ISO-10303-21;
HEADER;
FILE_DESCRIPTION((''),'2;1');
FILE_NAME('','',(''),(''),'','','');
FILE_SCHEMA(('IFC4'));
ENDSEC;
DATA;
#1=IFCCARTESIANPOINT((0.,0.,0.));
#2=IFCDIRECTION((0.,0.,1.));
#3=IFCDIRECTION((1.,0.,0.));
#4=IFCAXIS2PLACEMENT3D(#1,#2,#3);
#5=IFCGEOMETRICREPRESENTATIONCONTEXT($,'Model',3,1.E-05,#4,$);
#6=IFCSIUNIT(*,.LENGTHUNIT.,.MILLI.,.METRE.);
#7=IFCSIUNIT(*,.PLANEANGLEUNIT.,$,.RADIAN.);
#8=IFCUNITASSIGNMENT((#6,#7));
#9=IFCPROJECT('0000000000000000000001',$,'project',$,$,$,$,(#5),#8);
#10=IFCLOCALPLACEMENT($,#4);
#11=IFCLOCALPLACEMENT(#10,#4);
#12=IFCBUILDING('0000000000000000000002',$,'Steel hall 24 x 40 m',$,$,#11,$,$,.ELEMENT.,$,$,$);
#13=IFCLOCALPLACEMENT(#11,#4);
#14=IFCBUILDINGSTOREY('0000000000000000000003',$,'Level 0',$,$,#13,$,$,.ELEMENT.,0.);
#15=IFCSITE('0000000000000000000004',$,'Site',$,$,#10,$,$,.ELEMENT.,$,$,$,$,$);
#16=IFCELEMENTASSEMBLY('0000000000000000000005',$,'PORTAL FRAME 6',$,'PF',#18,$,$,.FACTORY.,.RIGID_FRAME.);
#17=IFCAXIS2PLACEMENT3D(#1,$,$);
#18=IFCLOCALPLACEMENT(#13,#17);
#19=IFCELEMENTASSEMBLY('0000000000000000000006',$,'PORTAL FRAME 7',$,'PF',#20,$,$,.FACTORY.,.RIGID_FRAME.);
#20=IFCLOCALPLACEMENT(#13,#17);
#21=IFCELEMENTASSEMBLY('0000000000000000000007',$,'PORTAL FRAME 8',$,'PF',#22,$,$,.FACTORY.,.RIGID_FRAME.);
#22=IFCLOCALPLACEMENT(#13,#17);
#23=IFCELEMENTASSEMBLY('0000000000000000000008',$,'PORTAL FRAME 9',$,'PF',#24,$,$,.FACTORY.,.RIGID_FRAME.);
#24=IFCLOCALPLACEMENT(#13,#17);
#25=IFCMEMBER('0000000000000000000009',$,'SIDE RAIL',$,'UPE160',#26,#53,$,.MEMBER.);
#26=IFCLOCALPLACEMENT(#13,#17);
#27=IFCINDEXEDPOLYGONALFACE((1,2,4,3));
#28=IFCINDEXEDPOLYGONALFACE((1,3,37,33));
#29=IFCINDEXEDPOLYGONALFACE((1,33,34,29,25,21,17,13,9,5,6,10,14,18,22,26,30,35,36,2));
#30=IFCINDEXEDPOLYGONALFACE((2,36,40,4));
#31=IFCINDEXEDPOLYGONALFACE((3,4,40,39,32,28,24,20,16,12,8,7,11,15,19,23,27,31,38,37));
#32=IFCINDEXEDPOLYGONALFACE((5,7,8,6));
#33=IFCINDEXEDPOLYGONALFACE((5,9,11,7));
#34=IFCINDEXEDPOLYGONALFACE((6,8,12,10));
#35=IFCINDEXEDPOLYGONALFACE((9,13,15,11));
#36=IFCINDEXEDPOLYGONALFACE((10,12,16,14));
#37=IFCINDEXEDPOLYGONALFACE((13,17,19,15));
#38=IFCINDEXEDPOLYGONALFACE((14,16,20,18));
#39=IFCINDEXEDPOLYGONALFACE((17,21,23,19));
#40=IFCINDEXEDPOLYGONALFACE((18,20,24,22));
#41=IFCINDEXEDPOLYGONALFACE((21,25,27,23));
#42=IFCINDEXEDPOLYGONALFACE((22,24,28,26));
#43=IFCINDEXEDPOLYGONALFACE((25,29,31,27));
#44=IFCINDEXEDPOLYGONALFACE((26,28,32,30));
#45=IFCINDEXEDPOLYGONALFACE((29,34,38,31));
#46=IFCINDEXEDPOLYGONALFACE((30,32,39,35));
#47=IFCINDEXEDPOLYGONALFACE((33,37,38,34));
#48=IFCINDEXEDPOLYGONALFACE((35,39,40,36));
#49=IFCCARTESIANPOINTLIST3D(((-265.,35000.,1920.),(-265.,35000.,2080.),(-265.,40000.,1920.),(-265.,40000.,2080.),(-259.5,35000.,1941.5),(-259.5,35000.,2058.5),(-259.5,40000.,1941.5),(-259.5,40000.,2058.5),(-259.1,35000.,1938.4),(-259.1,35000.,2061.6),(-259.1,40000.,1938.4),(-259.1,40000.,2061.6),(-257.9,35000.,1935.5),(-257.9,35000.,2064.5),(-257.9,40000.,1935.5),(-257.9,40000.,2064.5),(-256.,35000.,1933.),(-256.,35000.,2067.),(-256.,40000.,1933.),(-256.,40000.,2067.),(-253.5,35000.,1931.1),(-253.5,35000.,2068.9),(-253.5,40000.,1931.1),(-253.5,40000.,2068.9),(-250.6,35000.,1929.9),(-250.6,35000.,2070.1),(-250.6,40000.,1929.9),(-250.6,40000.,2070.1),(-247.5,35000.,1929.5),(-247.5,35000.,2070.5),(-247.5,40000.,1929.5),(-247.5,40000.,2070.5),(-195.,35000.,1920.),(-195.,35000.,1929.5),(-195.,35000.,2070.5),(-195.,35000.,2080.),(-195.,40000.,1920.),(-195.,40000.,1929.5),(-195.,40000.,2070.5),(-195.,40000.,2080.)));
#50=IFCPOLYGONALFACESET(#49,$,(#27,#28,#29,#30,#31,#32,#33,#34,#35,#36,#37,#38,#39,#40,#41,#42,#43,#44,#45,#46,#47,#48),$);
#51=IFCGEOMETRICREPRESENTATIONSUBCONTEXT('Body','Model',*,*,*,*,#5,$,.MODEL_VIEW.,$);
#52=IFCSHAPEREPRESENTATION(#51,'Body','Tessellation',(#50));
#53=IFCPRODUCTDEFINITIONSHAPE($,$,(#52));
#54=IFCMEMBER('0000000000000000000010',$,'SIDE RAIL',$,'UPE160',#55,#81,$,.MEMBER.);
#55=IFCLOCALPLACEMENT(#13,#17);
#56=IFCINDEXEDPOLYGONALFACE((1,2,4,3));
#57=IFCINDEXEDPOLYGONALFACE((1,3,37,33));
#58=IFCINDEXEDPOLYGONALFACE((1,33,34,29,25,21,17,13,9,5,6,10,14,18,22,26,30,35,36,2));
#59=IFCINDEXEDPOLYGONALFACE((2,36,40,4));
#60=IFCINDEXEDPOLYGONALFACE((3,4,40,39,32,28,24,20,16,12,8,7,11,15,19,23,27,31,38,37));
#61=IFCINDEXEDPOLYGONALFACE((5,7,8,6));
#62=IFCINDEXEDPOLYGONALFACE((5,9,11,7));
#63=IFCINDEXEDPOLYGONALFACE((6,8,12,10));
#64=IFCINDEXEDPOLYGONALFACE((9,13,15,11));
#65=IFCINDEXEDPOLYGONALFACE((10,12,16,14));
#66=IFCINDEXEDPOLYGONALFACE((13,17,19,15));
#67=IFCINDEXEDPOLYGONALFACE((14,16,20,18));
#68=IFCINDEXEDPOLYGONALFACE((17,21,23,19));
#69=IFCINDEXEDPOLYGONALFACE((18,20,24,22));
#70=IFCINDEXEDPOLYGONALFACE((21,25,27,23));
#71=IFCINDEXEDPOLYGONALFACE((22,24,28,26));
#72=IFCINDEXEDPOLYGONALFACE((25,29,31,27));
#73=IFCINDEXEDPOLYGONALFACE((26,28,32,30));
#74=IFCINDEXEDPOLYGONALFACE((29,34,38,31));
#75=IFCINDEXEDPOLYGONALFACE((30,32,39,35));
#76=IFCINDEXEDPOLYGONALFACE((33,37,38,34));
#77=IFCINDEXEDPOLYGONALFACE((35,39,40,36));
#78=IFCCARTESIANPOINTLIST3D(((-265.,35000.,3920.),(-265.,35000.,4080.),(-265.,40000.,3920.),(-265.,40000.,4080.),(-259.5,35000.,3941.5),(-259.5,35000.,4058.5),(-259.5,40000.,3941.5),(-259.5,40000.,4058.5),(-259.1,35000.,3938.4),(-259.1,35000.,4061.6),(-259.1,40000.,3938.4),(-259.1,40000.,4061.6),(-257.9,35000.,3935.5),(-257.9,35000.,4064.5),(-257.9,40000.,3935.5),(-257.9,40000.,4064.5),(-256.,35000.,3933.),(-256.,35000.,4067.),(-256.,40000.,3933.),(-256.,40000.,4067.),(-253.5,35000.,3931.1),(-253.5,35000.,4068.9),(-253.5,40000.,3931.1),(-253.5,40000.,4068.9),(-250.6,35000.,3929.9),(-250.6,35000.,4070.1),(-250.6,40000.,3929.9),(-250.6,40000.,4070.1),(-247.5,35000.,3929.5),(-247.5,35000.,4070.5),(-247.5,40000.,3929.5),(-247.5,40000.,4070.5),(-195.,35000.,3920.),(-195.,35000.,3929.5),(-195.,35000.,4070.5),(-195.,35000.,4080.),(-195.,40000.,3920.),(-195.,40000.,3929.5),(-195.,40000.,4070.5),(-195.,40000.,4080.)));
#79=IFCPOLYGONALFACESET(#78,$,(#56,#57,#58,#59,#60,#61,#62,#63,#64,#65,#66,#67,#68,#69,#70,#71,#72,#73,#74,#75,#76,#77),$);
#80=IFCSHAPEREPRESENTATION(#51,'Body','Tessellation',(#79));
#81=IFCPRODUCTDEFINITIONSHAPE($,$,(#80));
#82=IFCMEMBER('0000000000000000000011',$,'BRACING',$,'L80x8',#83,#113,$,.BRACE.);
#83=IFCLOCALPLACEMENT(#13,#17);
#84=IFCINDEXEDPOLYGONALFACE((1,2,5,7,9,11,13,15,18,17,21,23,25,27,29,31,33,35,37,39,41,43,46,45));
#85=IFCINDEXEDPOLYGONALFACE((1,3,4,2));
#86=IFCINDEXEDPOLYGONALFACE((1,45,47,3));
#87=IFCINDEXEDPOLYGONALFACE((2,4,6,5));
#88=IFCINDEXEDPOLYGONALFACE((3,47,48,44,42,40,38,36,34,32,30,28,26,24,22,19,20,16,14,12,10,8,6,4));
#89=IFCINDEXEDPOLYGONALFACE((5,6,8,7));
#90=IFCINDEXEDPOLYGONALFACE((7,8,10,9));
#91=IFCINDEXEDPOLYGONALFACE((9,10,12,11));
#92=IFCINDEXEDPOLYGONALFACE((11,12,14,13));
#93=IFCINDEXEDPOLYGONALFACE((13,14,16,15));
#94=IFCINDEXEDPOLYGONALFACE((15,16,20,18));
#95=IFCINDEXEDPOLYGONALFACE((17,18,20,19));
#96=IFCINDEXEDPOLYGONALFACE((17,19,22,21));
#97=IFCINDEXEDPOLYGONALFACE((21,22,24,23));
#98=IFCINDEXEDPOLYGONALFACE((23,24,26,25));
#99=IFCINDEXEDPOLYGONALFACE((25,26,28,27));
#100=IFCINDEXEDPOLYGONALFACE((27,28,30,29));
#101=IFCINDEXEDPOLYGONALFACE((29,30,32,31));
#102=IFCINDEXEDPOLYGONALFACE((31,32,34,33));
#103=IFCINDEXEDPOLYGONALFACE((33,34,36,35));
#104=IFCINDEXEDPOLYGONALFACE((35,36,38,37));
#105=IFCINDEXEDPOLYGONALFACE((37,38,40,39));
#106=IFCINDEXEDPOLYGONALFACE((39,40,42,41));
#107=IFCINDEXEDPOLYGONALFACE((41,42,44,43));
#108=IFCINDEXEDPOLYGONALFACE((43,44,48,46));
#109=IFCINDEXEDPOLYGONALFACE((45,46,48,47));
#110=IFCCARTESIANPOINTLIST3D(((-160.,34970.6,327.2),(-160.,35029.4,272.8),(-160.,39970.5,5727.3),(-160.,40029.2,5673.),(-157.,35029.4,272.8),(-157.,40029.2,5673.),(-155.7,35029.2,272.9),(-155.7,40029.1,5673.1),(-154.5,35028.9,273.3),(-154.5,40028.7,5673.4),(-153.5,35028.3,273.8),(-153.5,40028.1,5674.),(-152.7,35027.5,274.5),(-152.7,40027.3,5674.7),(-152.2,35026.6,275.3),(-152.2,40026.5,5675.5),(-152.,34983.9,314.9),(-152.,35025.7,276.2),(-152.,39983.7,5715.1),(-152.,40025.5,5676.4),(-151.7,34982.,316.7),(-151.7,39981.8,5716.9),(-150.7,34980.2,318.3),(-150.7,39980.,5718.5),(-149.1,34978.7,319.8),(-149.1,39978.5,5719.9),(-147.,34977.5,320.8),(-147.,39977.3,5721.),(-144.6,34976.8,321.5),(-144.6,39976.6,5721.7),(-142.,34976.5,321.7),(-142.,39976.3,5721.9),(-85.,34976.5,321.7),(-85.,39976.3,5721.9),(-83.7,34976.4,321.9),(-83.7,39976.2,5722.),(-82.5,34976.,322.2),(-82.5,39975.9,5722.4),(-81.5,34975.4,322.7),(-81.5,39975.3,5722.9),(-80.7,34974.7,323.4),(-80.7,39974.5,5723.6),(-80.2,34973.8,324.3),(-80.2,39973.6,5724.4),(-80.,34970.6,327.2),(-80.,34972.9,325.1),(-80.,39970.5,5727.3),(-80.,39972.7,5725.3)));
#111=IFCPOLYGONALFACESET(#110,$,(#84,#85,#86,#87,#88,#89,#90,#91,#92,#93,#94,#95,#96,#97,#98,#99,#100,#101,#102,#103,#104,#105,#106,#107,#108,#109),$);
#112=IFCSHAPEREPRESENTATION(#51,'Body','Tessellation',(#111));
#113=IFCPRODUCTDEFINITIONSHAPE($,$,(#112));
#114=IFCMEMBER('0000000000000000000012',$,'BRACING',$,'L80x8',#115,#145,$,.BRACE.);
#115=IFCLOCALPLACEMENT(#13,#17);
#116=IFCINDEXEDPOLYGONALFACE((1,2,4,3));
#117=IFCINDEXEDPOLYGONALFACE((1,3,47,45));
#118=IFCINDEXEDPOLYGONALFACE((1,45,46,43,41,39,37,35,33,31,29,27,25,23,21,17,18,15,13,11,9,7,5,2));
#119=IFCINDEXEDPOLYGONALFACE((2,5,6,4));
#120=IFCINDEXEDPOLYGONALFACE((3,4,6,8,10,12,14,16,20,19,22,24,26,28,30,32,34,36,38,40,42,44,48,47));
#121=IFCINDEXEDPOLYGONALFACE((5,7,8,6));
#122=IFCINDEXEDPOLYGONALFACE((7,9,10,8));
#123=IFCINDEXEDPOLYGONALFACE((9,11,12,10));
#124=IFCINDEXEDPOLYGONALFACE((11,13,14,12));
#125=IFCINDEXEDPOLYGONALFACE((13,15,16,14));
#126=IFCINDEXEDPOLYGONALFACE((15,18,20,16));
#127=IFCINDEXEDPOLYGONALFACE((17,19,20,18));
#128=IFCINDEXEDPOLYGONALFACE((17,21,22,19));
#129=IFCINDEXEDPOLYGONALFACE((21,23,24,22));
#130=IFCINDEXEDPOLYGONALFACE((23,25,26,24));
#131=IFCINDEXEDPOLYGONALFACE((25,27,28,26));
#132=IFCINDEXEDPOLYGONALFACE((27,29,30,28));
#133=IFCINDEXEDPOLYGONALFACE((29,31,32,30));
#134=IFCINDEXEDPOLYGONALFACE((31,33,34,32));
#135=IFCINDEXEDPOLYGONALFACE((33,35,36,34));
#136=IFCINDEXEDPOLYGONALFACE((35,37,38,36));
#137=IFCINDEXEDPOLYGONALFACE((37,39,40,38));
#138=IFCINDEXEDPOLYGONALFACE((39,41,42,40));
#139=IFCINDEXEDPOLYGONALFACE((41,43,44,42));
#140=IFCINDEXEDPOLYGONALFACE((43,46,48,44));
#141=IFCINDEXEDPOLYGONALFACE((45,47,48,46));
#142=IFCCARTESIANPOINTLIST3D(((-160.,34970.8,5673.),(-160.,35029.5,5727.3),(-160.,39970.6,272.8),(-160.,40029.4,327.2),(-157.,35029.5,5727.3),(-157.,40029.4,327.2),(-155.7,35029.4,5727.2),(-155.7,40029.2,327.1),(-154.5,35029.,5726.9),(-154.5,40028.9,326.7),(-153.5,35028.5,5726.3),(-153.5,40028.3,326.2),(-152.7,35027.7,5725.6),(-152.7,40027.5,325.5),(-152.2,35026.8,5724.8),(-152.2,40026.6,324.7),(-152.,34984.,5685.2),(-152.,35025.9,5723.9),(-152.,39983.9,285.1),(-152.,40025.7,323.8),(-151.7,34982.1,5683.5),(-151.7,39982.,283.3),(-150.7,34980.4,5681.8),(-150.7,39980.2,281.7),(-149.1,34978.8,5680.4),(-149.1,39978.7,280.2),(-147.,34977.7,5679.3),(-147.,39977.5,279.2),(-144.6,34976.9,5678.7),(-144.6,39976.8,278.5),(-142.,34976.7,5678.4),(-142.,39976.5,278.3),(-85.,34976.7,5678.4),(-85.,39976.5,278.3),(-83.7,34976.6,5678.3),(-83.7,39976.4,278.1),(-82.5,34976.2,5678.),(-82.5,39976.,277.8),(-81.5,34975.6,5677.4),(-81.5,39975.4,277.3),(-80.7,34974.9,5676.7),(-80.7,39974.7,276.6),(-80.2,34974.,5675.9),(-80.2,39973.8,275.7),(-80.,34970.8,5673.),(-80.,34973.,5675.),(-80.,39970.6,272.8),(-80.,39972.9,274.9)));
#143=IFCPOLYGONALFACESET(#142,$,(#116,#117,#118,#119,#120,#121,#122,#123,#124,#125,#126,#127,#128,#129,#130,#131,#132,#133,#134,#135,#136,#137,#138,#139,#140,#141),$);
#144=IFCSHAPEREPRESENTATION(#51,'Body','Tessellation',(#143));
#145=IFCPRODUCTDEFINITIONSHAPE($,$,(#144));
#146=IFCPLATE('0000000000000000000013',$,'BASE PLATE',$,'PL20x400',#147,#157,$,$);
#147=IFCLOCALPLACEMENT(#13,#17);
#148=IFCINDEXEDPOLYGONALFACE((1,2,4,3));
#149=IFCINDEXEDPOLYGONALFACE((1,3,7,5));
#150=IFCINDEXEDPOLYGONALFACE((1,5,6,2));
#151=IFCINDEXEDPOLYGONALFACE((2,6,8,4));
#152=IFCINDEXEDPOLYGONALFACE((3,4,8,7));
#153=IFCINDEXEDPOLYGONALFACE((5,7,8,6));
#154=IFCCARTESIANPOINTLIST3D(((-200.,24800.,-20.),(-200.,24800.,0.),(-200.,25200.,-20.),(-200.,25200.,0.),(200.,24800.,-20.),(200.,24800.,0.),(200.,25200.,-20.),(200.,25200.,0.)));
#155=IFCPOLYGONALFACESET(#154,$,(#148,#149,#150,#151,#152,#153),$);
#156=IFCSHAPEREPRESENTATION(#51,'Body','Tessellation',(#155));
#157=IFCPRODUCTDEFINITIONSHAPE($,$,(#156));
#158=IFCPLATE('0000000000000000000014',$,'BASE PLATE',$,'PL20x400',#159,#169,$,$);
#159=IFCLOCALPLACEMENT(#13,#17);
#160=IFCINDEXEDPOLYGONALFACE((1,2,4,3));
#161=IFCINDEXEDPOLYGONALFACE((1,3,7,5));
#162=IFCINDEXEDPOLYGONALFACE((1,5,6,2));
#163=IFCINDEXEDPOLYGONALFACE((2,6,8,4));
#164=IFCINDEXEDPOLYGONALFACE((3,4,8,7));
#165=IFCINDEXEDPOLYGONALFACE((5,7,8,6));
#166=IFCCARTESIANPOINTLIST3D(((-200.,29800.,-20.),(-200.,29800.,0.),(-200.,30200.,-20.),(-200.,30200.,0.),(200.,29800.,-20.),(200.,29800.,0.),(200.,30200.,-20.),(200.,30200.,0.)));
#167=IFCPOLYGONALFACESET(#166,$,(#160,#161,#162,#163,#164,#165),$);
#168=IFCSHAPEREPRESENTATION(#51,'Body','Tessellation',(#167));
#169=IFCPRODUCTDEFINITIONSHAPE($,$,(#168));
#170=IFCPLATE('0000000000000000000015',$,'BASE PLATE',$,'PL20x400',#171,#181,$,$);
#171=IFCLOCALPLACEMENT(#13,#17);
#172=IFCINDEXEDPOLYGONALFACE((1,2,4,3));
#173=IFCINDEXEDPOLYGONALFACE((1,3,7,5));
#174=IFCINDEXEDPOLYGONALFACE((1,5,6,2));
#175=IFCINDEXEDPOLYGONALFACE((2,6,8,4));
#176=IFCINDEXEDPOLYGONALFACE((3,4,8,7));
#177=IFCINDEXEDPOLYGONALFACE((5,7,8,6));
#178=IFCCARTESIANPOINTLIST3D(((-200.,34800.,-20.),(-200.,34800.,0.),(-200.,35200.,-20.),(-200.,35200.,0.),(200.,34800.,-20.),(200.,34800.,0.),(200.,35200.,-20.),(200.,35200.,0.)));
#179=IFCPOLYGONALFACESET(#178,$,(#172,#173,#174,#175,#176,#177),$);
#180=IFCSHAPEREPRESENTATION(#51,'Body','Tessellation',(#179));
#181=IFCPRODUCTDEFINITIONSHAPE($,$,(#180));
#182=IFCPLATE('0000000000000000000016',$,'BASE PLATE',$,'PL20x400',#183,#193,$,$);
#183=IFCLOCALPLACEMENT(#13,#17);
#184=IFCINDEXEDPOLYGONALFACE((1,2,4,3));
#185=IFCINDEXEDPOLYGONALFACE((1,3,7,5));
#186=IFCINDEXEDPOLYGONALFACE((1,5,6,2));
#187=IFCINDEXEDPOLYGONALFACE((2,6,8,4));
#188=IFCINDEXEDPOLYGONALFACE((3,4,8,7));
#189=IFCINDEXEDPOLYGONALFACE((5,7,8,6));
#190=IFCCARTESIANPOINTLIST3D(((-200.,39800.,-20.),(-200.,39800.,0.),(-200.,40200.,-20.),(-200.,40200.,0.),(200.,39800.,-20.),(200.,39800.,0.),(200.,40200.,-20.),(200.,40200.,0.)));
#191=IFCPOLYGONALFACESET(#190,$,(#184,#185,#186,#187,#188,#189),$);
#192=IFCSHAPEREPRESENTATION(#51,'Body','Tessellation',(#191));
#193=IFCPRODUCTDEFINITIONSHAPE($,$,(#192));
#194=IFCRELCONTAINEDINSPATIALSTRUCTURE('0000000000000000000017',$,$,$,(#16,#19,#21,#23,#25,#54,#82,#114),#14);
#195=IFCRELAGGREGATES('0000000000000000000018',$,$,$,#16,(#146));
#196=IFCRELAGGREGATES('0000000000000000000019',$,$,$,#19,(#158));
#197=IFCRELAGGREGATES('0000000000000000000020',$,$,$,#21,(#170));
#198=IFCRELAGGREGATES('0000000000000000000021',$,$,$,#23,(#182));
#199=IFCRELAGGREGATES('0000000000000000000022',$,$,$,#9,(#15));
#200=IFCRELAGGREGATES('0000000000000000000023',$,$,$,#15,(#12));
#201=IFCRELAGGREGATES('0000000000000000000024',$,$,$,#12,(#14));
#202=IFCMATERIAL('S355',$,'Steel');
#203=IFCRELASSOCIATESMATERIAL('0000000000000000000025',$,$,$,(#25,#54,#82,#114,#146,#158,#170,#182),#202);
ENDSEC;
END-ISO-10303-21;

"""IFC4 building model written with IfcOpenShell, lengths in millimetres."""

from ifc_helpers import new_model, si_unit, frame, origin_with_axes, place, context, subcontext, project, spatial, rectangle, l_section, u_section, extrude, material, element, aggregate, save


model = new_model("IFC4")

# Units and contexts
model_context = context("Model", 3, precision=1e-05, world=origin_with_axes())
body_context = subcontext(model_context, "Body", "Model", "MODEL_VIEW")
ifc_project = project(units=[si_unit("LENGTHUNIT", "METRE", prefix="MILLI"), si_unit("PLANEANGLEUNIT", "RADIAN")], contexts=[model_context])

# Site, building, storey
site_placement = place(None, origin_with_axes())
site = spatial("IfcSite", under=ifc_project, at=site_placement, Name="Site", CompositionType="ELEMENT")
building_placement = place(site_placement, origin_with_axes())
building = spatial("IfcBuilding", under=site, at=building_placement, Name="Steel hall 24 x 40 m", CompositionType="ELEMENT")
storey_placement = place(building_placement, origin_with_axes())
storey = spatial("IfcBuildingStorey", under=building, at=storey_placement, Name="Level 0", CompositionType="ELEMENT", Elevation=0.0)

# Element assemblies
assembly_1_placement = place(storey_placement, frame((0.0, 25000.0, 0.0), z_axis=(0.0, 0.0, 1.0), x_axis=(1.0, 0.0, 0.0)))
assembly_1 = element("IfcElementAssembly", 1, at=assembly_1_placement, inside=storey, Name="PORTAL FRAME 6", ObjectType="PF", AssemblyPlace="FACTORY", PredefinedType="RIGID_FRAME")
ifc_material = material(Name="S355", Category="Steel")
assembly_2_placement = place(storey_placement, frame((0.0, 30000.0, 0.0), z_axis=(0.0, 0.0, 1.0), x_axis=(1.0, 0.0, 0.0)))
assembly_2 = element("IfcElementAssembly", 2, at=assembly_2_placement, inside=storey, Name="PORTAL FRAME 7", ObjectType="PF", AssemblyPlace="FACTORY", PredefinedType="RIGID_FRAME")
assembly_3_placement = place(storey_placement, frame((0.0, 35000.0, 0.0), z_axis=(0.0, 0.0, 1.0), x_axis=(1.0, 0.0, 0.0)))
assembly_3 = element("IfcElementAssembly", 3, at=assembly_3_placement, inside=storey, Name="PORTAL FRAME 8", ObjectType="PF", AssemblyPlace="FACTORY", PredefinedType="RIGID_FRAME")
assembly_4_placement = place(storey_placement, frame((0.0, 40000.0, 0.0), z_axis=(0.0, 0.0, 1.0), x_axis=(1.0, 0.0, 0.0)))
assembly_4 = element("IfcElementAssembly", 4, at=assembly_4_placement, inside=storey, Name="PORTAL FRAME 9", ObjectType="PF", AssemblyPlace="FACTORY", PredefinedType="RIGID_FRAME")

# Members
for number, where, z_axis, x_axis, name in (
    (5, (-230.0, 35000.0, 2000.0), (0.0, 1.0, 0.0), (1.0, 0.0, 0.0), "SIDE RAIL"),
    (6, (-230.0, 35000.0, 4000.0), (0.0, 1.0, 0.0), (1.0, 0.0, 0.0), "SIDE RAIL"),
):
    element("IfcMember", number, at=place(storey_placement, frame(where, z_axis=z_axis, x_axis=x_axis)), inside=storey, material=ifc_material, Name=name, ObjectType="UPE160", PredefinedType="MEMBER", context=body_context, shape_type="SweptSolid", body=[
        extrude(u_section(Depth=160.0, FlangeWidth=70.0, WebThickness=5.5, FlangeThickness=9.5, FilletRadius=12.0), origin_with_axes(), (0.0, 0.0, 1.0), 5000.0),
    ])
for number, where, z_axis, x_axis, name in (
    (7, (-120.0, 35000.0, 300.0), (0.0, 0.6794, 0.7338), (1.0, 0.0, 0.0), "BRACING"),
    (8, (-120.0, 40000.0, 300.0), (0.0, -0.6794, 0.7338), (1.0, 0.0, 0.0), "BRACING"),
):
    element("IfcMember", number, at=place(storey_placement, frame(where, z_axis=z_axis, x_axis=x_axis)), inside=storey, material=ifc_material, Name=name, ObjectType="L80x8", PredefinedType="BRACE", context=body_context, shape_type="SweptSolid", body=[
        extrude(l_section(Depth=80.0, Width=80.0, Thickness=8.0, FilletRadius=10.0, EdgeRadius=5.0), origin_with_axes(), (0.0, 0.0, 1.0), 7359.3),
    ])

# Plates
plate_1_placement = place(storey_placement, frame((0.0, 25000.0, -20.0), z_axis=(0.0, 0.0, 1.0), x_axis=(1.0, 0.0, 0.0)))
plate_1 = element("IfcPlate", 9, at=plate_1_placement, material=ifc_material, Name="BASE PLATE", ObjectType="PL20x400", context=body_context, shape_type="SweptSolid", body=[
    extrude(rectangle(XDim=400.0, YDim=400.0), origin_with_axes(), (0.0, 0.0, 1.0), 20.0),
])
aggregate(assembly_1, [plate_1])
plate_2_placement = place(storey_placement, frame((0.0, 30000.0, -20.0), z_axis=(0.0, 0.0, 1.0), x_axis=(1.0, 0.0, 0.0)))
plate_2 = element("IfcPlate", 10, at=plate_2_placement, material=ifc_material, Name="BASE PLATE", ObjectType="PL20x400", context=body_context, shape_type="SweptSolid", body=[
    extrude(rectangle(XDim=400.0, YDim=400.0), origin_with_axes(), (0.0, 0.0, 1.0), 20.0),
])
aggregate(assembly_2, [plate_2])
plate_3_placement = place(storey_placement, frame((0.0, 35000.0, -20.0), z_axis=(0.0, 0.0, 1.0), x_axis=(1.0, 0.0, 0.0)))
plate_3 = element("IfcPlate", 11, at=plate_3_placement, material=ifc_material, Name="BASE PLATE", ObjectType="PL20x400", context=body_context, shape_type="SweptSolid", body=[
    extrude(rectangle(XDim=400.0, YDim=400.0), origin_with_axes(), (0.0, 0.0, 1.0), 20.0),
])
aggregate(assembly_3, [plate_3])
plate_4_placement = place(storey_placement, frame((0.0, 40000.0, -20.0), z_axis=(0.0, 0.0, 1.0), x_axis=(1.0, 0.0, 0.0)))
plate_4 = element("IfcPlate", 12, at=plate_4_placement, material=ifc_material, Name="BASE PLATE", ObjectType="PL20x400", context=body_context, shape_type="SweptSolid", body=[
    extrude(rectangle(XDim=400.0, YDim=400.0), origin_with_axes(), (0.0, 0.0, 1.0), 20.0),
])
aggregate(assembly_4, [plate_4])

save(model, "model.ifc")
